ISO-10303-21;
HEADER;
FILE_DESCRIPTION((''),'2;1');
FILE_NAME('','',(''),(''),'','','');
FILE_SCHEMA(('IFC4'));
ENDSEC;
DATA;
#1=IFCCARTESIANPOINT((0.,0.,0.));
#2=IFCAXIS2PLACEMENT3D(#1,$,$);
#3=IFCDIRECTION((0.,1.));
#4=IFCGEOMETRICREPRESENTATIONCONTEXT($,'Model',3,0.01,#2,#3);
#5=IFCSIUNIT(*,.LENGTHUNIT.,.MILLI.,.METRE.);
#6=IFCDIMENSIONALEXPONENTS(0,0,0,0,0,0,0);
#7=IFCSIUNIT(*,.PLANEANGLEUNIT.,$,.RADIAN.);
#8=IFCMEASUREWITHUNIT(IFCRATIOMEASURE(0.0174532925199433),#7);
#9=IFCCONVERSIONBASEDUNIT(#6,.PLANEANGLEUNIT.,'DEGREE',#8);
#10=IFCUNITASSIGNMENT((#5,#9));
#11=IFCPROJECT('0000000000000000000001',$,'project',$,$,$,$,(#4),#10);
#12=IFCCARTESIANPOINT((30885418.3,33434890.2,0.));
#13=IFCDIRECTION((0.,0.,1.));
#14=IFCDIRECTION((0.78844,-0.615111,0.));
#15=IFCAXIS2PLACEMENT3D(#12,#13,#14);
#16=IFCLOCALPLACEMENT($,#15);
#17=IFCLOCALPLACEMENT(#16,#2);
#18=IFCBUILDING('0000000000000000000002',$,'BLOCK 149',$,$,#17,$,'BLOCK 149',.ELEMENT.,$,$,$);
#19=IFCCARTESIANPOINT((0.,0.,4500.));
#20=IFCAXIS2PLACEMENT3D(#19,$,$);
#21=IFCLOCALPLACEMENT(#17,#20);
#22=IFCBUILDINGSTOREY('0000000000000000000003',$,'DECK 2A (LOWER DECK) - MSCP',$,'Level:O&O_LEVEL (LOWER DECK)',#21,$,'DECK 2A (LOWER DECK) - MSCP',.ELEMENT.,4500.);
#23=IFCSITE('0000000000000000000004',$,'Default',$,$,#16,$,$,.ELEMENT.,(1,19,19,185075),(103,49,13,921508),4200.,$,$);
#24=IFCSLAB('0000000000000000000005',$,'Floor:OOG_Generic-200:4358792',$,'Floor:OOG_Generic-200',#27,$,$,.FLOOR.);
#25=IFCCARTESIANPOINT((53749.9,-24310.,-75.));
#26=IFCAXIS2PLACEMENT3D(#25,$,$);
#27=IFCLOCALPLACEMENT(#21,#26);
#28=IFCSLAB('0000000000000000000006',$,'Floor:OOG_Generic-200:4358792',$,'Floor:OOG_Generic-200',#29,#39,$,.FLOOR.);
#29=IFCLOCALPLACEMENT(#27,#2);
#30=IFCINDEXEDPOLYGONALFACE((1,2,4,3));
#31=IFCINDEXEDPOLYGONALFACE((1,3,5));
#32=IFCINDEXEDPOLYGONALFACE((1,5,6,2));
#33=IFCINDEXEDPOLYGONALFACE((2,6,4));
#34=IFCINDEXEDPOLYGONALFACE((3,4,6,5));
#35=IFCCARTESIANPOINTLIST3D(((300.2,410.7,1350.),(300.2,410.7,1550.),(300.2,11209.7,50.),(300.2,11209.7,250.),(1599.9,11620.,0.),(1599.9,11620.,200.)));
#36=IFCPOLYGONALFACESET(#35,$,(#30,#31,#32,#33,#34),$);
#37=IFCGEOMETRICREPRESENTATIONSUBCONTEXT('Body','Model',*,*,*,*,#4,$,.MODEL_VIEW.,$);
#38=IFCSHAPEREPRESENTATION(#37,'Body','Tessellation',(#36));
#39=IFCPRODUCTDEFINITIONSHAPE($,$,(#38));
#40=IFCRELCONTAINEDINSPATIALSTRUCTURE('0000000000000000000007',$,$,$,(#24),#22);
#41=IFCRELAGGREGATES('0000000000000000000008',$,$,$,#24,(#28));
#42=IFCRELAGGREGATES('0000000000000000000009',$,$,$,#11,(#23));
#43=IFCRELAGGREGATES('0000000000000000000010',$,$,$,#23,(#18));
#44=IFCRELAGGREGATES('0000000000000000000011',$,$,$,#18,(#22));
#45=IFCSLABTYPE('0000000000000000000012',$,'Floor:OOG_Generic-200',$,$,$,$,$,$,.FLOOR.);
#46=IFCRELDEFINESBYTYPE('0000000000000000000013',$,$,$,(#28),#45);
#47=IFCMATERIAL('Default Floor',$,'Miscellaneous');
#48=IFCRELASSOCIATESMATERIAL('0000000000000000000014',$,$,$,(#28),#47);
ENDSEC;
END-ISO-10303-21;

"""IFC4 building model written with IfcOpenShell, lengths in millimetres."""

from ifc_helpers import new_model, entity, si_unit, converted_unit, direction, frame, origin, place, context, subcontext, project, spatial, indexed_curve, outline, extrude, material, type_object, element, aggregate, save


model = new_model("IFC4")

# Units and contexts
model_context = context("Model", 3, precision=0.01, world=origin(), true_north=direction((0.0, 1.0)))
body_context = subcontext(model_context, "Body", "Model", "MODEL_VIEW")
ifc_project = project(units=[si_unit("LENGTHUNIT", "METRE", prefix="MILLI"), converted_unit("PLANEANGLEUNIT", "DEGREE", entity("IfcRatioMeasure", 0.0174532925199433), si_unit("PLANEANGLEUNIT", "RADIAN"), dimensions=[0, 0, 0, 0, 0, 0, 0])], contexts=[model_context])

# Site, building, storey
site_placement = place(None, frame((30885418.3, 33434890.2, 0.0), z_axis=(0.0, 0.0, 1.0), x_axis=(0.78844, -0.615111, 0.0)))
site = spatial("IfcSite", under=ifc_project, at=site_placement, Name="Default", CompositionType="ELEMENT", RefLatitude=(1, 19, 19, 185075), RefLongitude=(103, 49, 13, 921508), RefElevation=4200.0)
building_placement = place(site_placement, origin())
building = spatial("IfcBuilding", under=site, at=building_placement, Name="BLOCK 149", LongName="BLOCK 149", CompositionType="ELEMENT")
storey_placement = place(building_placement, frame((0.0, 0.0, 4500.0)))
storey = spatial("IfcBuildingStorey", under=building, at=storey_placement, Name="DECK 2A (LOWER DECK) - MSCP", ObjectType="Level:O&O_LEVEL (LOWER DECK)", LongName="DECK 2A (LOWER DECK) - MSCP", CompositionType="ELEMENT", Elevation=4500.0)

# Slabs
slab_1_placement = place(storey_placement, frame((53749.9, -24310.0, -75.0)))
slab_1 = element("IfcSlab", 1, at=slab_1_placement, inside=storey, Name="Floor:OOG_Generic-200:4358792", ObjectType="Floor:OOG_Generic-200", PredefinedType="FLOOR")
ifc_material_1 = material(Name="Default Floor", Category="Miscellaneous")
slab_type_1 = type_object("IfcSlabType", Name="Floor:OOG_Generic-200", PredefinedType="FLOOR")
slab_2_placement = place(slab_1_placement, origin())
slab_2 = element("IfcSlab", 2, at=slab_2_placement, type_object=slab_type_1, material=ifc_material_1, Name="Floor:OOG_Generic-200:4358792", ObjectType="Floor:OOG_Generic-200", PredefinedType="FLOOR", context=body_context, shape_type="SweptSolid", body=[
    extrude(outline(indexed_curve([(649.9, 5645.1), (-649.9, 5231.8), (-649.9, -5645.1), (649.9, 5645.1)], self_intersect=False)), frame((950.0, 6015.4, 875.0), z_axis=(0.000465, 0.119519, 0.992832), x_axis=(1.0, -0.000056, -0.000462)), (0.000462, 0.119519, -0.992832), 200.0),
])
aggregate(slab_1, [slab_2])

save(model, "model.ifc")
